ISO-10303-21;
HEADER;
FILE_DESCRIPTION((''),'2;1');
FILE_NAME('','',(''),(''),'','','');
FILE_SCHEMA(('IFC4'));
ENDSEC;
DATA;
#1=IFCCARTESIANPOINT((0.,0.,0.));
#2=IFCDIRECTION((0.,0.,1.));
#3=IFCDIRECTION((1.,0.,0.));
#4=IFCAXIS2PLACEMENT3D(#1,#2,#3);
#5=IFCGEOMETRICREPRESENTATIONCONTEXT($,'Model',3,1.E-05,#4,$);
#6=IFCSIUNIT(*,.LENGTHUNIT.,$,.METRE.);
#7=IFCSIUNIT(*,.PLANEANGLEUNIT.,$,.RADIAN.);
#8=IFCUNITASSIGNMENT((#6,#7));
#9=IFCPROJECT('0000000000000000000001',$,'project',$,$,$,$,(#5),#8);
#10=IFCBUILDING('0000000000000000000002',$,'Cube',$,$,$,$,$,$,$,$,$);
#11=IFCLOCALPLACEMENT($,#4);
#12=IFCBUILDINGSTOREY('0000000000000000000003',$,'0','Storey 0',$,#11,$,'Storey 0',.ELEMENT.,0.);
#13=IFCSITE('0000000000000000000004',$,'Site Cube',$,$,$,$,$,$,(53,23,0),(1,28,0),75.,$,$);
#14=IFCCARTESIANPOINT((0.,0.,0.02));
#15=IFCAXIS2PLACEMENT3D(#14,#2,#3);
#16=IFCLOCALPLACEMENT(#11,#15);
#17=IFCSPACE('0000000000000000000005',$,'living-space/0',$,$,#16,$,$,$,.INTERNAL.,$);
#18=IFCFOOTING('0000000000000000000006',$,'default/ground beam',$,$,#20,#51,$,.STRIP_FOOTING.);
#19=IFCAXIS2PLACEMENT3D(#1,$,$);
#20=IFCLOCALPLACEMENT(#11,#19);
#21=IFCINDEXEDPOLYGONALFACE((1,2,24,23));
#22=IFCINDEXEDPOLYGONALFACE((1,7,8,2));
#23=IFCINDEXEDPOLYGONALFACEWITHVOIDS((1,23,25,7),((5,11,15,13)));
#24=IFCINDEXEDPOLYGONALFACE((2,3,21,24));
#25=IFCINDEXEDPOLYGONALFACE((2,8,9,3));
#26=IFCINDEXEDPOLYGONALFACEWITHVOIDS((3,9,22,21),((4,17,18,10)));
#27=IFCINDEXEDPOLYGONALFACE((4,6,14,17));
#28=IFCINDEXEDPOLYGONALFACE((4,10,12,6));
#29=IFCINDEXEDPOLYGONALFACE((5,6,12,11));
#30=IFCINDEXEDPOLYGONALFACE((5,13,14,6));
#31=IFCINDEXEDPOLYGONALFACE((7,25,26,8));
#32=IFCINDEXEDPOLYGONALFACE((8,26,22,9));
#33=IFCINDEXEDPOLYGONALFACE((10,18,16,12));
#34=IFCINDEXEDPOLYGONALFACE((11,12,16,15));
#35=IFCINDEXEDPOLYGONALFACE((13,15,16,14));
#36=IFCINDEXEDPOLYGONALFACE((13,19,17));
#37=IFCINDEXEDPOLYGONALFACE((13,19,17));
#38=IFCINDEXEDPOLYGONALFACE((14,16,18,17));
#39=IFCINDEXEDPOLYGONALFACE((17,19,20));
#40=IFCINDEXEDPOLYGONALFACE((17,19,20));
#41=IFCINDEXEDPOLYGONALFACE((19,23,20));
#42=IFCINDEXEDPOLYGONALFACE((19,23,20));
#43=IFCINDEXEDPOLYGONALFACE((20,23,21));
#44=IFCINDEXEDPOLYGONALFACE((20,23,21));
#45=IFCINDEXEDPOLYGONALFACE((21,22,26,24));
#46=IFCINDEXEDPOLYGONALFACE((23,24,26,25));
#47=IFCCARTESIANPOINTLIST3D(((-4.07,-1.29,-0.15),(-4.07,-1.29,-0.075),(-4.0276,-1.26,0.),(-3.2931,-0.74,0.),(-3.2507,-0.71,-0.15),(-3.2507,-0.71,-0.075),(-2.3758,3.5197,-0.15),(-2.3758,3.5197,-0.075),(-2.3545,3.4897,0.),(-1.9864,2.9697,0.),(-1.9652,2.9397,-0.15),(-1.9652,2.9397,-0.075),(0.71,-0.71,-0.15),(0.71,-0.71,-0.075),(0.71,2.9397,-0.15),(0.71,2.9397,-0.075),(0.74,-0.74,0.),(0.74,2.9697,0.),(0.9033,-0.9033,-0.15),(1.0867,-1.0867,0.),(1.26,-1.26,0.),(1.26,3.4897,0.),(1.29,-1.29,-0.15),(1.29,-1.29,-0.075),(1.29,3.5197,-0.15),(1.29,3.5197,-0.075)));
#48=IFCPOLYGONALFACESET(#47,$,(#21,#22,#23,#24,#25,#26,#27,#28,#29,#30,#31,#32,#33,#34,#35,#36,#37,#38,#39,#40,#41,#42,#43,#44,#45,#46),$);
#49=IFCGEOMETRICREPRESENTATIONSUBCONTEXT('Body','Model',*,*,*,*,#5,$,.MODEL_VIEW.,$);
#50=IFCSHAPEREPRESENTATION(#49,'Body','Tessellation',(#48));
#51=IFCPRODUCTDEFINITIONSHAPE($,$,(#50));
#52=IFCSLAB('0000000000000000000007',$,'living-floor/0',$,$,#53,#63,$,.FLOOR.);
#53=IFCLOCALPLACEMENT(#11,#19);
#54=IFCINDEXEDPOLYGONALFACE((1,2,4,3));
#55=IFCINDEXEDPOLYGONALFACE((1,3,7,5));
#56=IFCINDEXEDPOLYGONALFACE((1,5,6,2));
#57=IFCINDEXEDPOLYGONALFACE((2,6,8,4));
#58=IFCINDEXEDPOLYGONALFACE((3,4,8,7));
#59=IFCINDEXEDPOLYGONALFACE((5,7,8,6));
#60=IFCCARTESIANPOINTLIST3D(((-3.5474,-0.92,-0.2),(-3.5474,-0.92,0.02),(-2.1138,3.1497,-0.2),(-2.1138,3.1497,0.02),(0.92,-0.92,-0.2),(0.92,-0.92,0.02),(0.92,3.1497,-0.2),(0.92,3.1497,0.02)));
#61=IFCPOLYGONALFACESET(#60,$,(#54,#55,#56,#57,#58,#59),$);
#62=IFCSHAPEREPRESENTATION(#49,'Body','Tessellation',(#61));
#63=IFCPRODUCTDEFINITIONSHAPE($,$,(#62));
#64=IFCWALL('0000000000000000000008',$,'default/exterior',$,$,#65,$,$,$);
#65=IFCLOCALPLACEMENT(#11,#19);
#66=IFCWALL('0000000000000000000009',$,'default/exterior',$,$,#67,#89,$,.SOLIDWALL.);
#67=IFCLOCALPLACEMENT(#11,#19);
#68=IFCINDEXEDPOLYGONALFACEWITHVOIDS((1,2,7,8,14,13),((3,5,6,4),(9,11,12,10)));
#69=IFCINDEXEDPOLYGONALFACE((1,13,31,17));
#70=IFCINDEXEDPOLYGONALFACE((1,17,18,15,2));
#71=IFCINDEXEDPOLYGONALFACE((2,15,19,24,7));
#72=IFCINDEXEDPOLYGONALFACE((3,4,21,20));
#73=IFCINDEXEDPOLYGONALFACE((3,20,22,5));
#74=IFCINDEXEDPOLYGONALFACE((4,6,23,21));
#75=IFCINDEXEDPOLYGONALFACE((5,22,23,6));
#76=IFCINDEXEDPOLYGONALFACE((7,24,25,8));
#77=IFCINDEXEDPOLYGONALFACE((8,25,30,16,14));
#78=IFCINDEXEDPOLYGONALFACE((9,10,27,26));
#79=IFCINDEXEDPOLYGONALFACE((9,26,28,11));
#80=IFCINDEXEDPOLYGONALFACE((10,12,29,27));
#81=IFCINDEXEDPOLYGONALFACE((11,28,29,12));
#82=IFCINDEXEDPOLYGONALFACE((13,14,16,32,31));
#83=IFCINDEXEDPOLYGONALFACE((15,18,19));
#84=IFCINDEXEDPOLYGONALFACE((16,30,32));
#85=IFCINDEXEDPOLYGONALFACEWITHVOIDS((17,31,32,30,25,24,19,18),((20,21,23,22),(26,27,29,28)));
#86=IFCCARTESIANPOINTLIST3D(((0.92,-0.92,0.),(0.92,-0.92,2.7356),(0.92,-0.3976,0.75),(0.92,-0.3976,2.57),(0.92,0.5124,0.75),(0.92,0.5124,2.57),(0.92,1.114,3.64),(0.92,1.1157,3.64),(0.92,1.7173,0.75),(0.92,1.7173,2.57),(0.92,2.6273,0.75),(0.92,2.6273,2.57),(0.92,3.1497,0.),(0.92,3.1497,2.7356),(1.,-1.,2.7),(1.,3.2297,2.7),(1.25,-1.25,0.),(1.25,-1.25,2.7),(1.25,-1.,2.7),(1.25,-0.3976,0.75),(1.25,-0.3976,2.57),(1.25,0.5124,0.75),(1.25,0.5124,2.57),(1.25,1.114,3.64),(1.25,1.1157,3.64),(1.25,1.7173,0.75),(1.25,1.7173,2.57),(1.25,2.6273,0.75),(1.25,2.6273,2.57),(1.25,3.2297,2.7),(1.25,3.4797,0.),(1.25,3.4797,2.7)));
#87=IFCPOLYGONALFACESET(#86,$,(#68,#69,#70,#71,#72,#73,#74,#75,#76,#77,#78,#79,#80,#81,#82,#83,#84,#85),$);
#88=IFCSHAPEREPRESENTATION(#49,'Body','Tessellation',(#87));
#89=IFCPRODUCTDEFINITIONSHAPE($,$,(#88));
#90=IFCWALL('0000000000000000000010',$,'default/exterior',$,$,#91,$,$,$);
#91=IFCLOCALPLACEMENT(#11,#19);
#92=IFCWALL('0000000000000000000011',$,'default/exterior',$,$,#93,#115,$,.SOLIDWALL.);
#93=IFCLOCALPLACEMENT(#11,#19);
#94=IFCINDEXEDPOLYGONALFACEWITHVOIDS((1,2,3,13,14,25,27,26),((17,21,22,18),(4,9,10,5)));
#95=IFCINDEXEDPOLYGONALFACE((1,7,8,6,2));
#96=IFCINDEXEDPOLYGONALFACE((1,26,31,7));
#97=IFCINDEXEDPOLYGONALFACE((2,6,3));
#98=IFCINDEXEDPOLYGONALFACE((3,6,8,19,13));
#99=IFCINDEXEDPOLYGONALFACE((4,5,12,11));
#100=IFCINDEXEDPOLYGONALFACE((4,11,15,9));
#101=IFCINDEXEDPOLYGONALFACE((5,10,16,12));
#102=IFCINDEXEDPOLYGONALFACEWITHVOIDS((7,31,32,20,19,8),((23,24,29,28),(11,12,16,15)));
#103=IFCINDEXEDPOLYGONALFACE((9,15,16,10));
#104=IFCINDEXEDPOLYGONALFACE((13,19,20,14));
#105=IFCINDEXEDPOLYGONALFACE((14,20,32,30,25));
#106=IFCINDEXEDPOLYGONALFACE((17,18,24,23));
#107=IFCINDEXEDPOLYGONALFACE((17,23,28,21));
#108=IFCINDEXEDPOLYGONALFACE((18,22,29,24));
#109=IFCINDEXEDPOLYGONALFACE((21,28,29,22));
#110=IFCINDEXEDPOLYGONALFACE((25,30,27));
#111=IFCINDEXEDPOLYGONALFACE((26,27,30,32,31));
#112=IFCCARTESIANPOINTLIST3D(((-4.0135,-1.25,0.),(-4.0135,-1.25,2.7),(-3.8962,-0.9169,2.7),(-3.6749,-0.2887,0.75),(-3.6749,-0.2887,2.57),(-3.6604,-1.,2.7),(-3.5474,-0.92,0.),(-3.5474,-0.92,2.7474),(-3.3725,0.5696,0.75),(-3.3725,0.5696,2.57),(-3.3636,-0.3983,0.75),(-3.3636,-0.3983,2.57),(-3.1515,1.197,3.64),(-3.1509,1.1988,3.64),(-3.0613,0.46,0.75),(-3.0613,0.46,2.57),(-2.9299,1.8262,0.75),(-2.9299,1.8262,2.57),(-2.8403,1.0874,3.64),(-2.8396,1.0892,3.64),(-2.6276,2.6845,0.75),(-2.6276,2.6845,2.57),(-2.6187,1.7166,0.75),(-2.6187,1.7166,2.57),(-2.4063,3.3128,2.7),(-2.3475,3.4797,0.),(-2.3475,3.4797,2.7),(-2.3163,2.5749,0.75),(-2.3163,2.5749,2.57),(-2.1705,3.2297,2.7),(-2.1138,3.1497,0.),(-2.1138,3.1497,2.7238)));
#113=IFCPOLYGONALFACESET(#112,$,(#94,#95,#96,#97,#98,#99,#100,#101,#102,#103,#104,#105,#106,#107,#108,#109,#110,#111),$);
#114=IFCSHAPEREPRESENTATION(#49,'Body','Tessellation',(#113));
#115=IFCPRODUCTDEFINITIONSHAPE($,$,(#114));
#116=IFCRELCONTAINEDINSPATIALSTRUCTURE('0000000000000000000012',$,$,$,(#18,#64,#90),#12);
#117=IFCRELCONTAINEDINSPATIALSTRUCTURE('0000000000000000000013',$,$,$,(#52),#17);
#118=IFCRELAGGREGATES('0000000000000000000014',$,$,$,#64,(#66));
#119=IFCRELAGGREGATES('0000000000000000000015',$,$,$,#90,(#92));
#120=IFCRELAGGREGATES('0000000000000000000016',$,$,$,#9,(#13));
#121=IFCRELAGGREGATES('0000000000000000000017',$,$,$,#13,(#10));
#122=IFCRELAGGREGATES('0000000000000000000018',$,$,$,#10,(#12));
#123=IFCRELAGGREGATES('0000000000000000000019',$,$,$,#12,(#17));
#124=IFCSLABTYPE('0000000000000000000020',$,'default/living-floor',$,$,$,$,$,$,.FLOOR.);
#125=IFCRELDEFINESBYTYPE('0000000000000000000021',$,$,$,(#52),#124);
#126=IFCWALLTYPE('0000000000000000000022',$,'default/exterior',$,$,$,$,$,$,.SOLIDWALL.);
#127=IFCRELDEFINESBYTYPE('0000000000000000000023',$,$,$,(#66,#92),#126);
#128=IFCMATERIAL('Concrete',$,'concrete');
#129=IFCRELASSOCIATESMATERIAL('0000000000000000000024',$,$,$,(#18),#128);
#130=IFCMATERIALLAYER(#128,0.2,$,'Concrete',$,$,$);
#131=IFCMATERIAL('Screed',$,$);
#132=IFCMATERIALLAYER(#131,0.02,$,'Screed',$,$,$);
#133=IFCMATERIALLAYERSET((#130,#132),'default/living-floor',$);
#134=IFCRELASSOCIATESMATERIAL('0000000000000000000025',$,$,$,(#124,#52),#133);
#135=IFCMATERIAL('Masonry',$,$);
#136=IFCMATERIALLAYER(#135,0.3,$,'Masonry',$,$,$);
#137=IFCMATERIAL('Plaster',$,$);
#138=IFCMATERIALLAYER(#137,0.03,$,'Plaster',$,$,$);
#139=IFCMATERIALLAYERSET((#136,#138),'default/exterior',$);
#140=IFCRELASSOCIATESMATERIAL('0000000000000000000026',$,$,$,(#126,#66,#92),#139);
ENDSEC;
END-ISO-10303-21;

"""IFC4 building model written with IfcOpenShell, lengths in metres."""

from ifc_helpers import new_model, entity, si_unit, frame, origin, origin_with_axes, place, context, subcontext, project, spatial, polyline, outline, extrude, clip, bounded_halfspace, material, layer, layer_set, layer_usage, type_object, element, aggregate, save


model = new_model("IFC4")

# Units and contexts
model_context = context("Model", 3, precision=1e-05, world=origin_with_axes())
body_context = subcontext(model_context, "Body", "Model", "MODEL_VIEW")
ifc_project = project(units=[si_unit("LENGTHUNIT", "METRE"), si_unit("PLANEANGLEUNIT", "RADIAN")], contexts=[model_context])

# Site, building, storey
site = spatial("IfcSite", under=ifc_project, Name="Site Cube", RefLatitude=(53, 23, 0), RefLongitude=(1, 28, 0), RefElevation=75.0)
building = spatial("IfcBuilding", under=site, Name="Cube")
storey_placement = place(None, origin_with_axes())
storey = spatial("IfcBuildingStorey", under=building, at=storey_placement, Name="0", Description="Storey 0", LongName="Storey 0", CompositionType="ELEMENT", Elevation=0.0)

# Footing
ifc_material_1 = material(Name="Concrete", Category="concrete")
footing_placement = place(storey_placement, origin_with_axes())
axis2_placement3_d = entity("IfcAxis2Placement3D", entity("IfcCartesianPoint", [0.0, 0.0, 0.0]))
element("IfcFooting", 1, at=footing_placement, inside=storey, material=ifc_material_1, Name="default/ground beam", PredefinedType="STRIP_FOOTING", context=body_context, shape_type="AdvancedSweptSolid", body=[
    entity("IfcSurfaceCurveSweptAreaSolid", entity("IfcDerivedProfileDef", "AREA", None, entity("IfcArbitraryClosedProfileDef", "AREA", None, entity("IfcPolyline", [entity("IfcCartesianPoint", [0.0, -0.26]), entity("IfcCartesianPoint", [-0.075, -0.29]), entity("IfcCartesianPoint", [-0.15, -0.29]), entity("IfcCartesianPoint", [-0.15, 0.29]), entity("IfcCartesianPoint", [-0.075, 0.29]), entity("IfcCartesianPoint", [0.0, 0.26]), entity("IfcCartesianPoint", [0.0, -0.26])])), entity("IfcCartesianTransformationOperator2D", None, None, entity("IfcCartesianPoint", [0.0, 0.0]), 1.0)), axis2_placement3_d, entity("IfcPolyline", [entity("IfcCartesianPoint", [1.0, -1.0]), entity("IfcCartesianPoint", [1.0, 3.2297]), entity("IfcCartesianPoint", [-2.1705, 3.2297]), entity("IfcCartesianPoint", [-3.6604, -1.0]), entity("IfcCartesianPoint", [1.0, -1.0])]), 0.0, 1.0, entity("IfcPlane", axis2_placement3_d)),
])

# Shared definitions
space_placement = place(storey_placement, frame((0.0, 0.0, 0.02), z_axis=(0.0, 0.0, 1.0), x_axis=(1.0, 0.0, 0.0)))
space = spatial("IfcSpace", under=storey, at=space_placement, Name="living-space/0", PredefinedType="INTERNAL")

# Slab
ifc_layer_1 = layer(ifc_material_1, 0.2, Name="Concrete")
ifc_material_2 = material(Name="Screed")
ifc_layer_2 = layer(ifc_material_2, 0.02, Name="Screed")
ifc_layer_set_1 = layer_set([ifc_layer_1, ifc_layer_2], Name="default/living-floor")
ifc_layer_usage_1 = layer_usage(ifc_layer_set_1, "AXIS3", "POSITIVE", -0.2)
slab_type = type_object("IfcSlabType", Name="default/living-floor", PredefinedType="FLOOR", material=ifc_layer_set_1)
slab_placement = place(space_placement, frame((0.0, 0.0, -0.22), z_axis=(0.0, 0.0, 1.0), x_axis=(1.0, 0.0, 0.0)))
element("IfcSlab", 2, at=slab_placement, inside=space, type_object=slab_type, material=ifc_layer_usage_1, Name="living-floor/0", PredefinedType="FLOOR", context=body_context, shape_type="SweptSolid", body=[
    extrude(outline(polyline([(-3.5474, -0.92), (0.92, -0.92), (0.92, 3.1497), (-2.1138, 3.1497), (-3.5474, -0.92)])), origin(), (0.0, 0.0, 1.0), 0.22),
])

# Walls, openings
wall_1_placement = place(storey_placement, frame((1.0, -1.0, 0.0), z_axis=(0.0, 0.0, 1.0), x_axis=(0.0, 1.0, 0.0)))
wall_1 = element("IfcWall", 3, at=wall_1_placement, inside=storey, Name="default/exterior")
ifc_material_3 = material(Name="Masonry")
ifc_layer_3 = layer(ifc_material_3, 0.3, Name="Masonry")
ifc_material_4 = material(Name="Plaster")
ifc_layer_4 = layer(ifc_material_4, 0.03, Name="Plaster")
ifc_layer_set_2 = layer_set([ifc_layer_3, ifc_layer_4], Name="default/exterior")
ifc_layer_usage_2 = layer_usage(ifc_layer_set_2, "AXIS2", "POSITIVE", -0.25)
wall_type = type_object("IfcWallType", Name="default/exterior", PredefinedType="SOLIDWALL", material=ifc_layer_set_2)
wall_2_placement = place(wall_1_placement, origin_with_axes())
wall_2 = element("IfcWall", 4, at=wall_2_placement, type_object=wall_type, material=ifc_layer_usage_2, Name="default/exterior", PredefinedType="SOLIDWALL", context=body_context, shape_type="Clipping", body=[
    clip(clip(clip(clip(extrude(outline(polyline([(0.08, 0.08), (-0.25, -0.25), (4.4797, -0.25), (4.1497, 0.08), (0.08, 0.08)])), origin(), (0.0, 0.0, 1.0), 3.64), bounded_halfspace(frame((4.2297, 0.0, 2.7), z_axis=(0.406302, 0.0, 0.913739)), False, origin(), polyline([(4.2297, -1.0), (2.1149, -1.0), (2.1149, 1.0), (4.2297, 1.0), (4.2297, -1.0)]))), bounded_halfspace(frame((4.2297, 0.0, 2.7), z_axis=(0.0, 0.0, 1.0)), False, origin(), polyline([(4.2297, 1.0), (5.2297, 1.0), (5.2297, -1.0), (4.2297, -1.0), (4.2297, 1.0)]))), bounded_halfspace(frame((2.1149, 0.0, 3.6404), z_axis=(-0.406302, 0.0, 0.913739)), False, origin(), polyline([(2.1149, -1.0), (0.0, -1.0), (0.0, 1.0), (2.1149, 1.0), (2.1149, -1.0)]))), bounded_halfspace(frame((0.0, 0.0, 2.7), z_axis=(0.0, 0.0, 1.0)), False, origin(), polyline([(0.0, -1.0), (-1.0, -1.0), (-1.0, 1.0), (0.0, 1.0), (0.0, -1.0)]))),
])
opening_1_placement = place(None, frame((1.25, -0.3976, 0.75), z_axis=(0.0, 0.0, 1.0), x_axis=(0.0, 1.0, 0.0)))
element("IfcOpeningElement", 5, at=opening_1_placement, cuts=wall_2, PredefinedType="OPENING", context=body_context, shape_type="SweptSolid", body=[
    extrude(outline(polyline([(0.0, -0.02), (0.91, -0.02), (0.91, 0.35), (0.0, 0.35), (0.0, -0.02)])), origin(), (0.0, 0.0, 1.0), 1.82),
])
opening_2_placement = place(None, frame((1.25, 1.7173, 0.75), z_axis=(0.0, 0.0, 1.0), x_axis=(0.0, 1.0, 0.0)))
element("IfcOpeningElement", 6, at=opening_2_placement, cuts=wall_2, PredefinedType="OPENING", context=body_context, shape_type="SweptSolid", body=[
    extrude(outline(polyline([(0.0, -0.02), (0.91, -0.02), (0.91, 0.35), (0.0, 0.35), (0.0, -0.02)])), origin(), (0.0, 0.0, 1.0), 1.82),
])
aggregate(wall_1, [wall_2])
wall_3_placement = place(storey_placement, frame((-2.1705, 3.2297, 0.0), z_axis=(0.0, 0.0, 1.0), x_axis=(-0.332236, -0.943196, 0.0)))
wall_3 = element("IfcWall", 7, at=wall_3_placement, inside=storey, Name="default/exterior")
ifc_layer_usage_3 = layer_usage(ifc_layer_set_2, "AXIS2", "POSITIVE", -0.25)
wall_4_placement = place(wall_3_placement, frame((0.0, 0.0, 0.0), z_axis=(0.0, 0.0, 1.0), x_axis=(1.0, 0.0, 0.0)))
wall_4 = element("IfcWall", 8, at=wall_4_placement, type_object=wall_type, material=ifc_layer_usage_3, Name="default/exterior", PredefinedType="SOLIDWALL", context=body_context, shape_type="Clipping", body=[
    clip(clip(clip(clip(extrude(outline(polyline([(0.0566, 0.08), (-0.177, -0.25), (4.8376, -0.25), (4.3715, 0.08), (0.0566, 0.08)])), origin(), (0.0, 0.0, 1.0), 3.64), bounded_halfspace(frame((4.4844, 0.0, 2.7), z_axis=(0.386762, 0.0, 0.922179)), False, origin(), polyline([(4.4844, -1.0), (2.2422, -1.0), (2.2422, 1.0), (4.4844, 1.0), (4.4844, -1.0)]))), bounded_halfspace(frame((4.4844, 0.0, 2.7), z_axis=(0.0, 0.0, 1.0)), False, origin(), polyline([(4.4844, 1.0), (5.4844, 1.0), (5.4844, -1.0), (4.4844, -1.0), (4.4844, 1.0)]))), bounded_halfspace(frame((2.2422, 0.0, 3.6404), z_axis=(-0.386762, 0.0, 0.922179)), False, origin(), polyline([(2.2422, -1.0), (0.0, -1.0), (0.0, 1.0), (2.2422, 1.0), (2.2422, -1.0)]))), bounded_halfspace(frame((0.0, 0.0, 2.7), z_axis=(0.0, 0.0, 1.0)), False, origin(), polyline([(0.0, -1.0), (-1.0, -1.0), (-1.0, 1.0), (0.0, 1.0), (0.0, -1.0)]))),
])
opening_3_placement = place(None, frame((-2.6276, 2.6845, 0.75), z_axis=(0.0, 0.0, 1.0), x_axis=(-0.332236, -0.943196, 0.0)))
element("IfcOpeningElement", 9, at=opening_3_placement, cuts=wall_4, PredefinedType="OPENING", context=body_context, shape_type="SweptSolid", body=[
    extrude(outline(polyline([(0.0, -0.02), (0.91, -0.02), (0.91, 0.35), (0.0, 0.35), (0.0, -0.02)])), origin(), (0.0, 0.0, 1.0), 1.82),
])
opening_4_placement = place(None, frame((-3.3725, 0.5696, 0.75), z_axis=(0.0, 0.0, 1.0), x_axis=(-0.332236, -0.943196, 0.0)))
element("IfcOpeningElement", 10, at=opening_4_placement, cuts=wall_4, PredefinedType="OPENING", context=body_context, shape_type="SweptSolid", body=[
    extrude(outline(polyline([(0.0, -0.02), (0.91, -0.02), (0.91, 0.35), (0.0, 0.35), (0.0, -0.02)])), origin(), (0.0, 0.0, 1.0), 1.82),
])
aggregate(wall_3, [wall_4])

save(model, "model.ifc")
